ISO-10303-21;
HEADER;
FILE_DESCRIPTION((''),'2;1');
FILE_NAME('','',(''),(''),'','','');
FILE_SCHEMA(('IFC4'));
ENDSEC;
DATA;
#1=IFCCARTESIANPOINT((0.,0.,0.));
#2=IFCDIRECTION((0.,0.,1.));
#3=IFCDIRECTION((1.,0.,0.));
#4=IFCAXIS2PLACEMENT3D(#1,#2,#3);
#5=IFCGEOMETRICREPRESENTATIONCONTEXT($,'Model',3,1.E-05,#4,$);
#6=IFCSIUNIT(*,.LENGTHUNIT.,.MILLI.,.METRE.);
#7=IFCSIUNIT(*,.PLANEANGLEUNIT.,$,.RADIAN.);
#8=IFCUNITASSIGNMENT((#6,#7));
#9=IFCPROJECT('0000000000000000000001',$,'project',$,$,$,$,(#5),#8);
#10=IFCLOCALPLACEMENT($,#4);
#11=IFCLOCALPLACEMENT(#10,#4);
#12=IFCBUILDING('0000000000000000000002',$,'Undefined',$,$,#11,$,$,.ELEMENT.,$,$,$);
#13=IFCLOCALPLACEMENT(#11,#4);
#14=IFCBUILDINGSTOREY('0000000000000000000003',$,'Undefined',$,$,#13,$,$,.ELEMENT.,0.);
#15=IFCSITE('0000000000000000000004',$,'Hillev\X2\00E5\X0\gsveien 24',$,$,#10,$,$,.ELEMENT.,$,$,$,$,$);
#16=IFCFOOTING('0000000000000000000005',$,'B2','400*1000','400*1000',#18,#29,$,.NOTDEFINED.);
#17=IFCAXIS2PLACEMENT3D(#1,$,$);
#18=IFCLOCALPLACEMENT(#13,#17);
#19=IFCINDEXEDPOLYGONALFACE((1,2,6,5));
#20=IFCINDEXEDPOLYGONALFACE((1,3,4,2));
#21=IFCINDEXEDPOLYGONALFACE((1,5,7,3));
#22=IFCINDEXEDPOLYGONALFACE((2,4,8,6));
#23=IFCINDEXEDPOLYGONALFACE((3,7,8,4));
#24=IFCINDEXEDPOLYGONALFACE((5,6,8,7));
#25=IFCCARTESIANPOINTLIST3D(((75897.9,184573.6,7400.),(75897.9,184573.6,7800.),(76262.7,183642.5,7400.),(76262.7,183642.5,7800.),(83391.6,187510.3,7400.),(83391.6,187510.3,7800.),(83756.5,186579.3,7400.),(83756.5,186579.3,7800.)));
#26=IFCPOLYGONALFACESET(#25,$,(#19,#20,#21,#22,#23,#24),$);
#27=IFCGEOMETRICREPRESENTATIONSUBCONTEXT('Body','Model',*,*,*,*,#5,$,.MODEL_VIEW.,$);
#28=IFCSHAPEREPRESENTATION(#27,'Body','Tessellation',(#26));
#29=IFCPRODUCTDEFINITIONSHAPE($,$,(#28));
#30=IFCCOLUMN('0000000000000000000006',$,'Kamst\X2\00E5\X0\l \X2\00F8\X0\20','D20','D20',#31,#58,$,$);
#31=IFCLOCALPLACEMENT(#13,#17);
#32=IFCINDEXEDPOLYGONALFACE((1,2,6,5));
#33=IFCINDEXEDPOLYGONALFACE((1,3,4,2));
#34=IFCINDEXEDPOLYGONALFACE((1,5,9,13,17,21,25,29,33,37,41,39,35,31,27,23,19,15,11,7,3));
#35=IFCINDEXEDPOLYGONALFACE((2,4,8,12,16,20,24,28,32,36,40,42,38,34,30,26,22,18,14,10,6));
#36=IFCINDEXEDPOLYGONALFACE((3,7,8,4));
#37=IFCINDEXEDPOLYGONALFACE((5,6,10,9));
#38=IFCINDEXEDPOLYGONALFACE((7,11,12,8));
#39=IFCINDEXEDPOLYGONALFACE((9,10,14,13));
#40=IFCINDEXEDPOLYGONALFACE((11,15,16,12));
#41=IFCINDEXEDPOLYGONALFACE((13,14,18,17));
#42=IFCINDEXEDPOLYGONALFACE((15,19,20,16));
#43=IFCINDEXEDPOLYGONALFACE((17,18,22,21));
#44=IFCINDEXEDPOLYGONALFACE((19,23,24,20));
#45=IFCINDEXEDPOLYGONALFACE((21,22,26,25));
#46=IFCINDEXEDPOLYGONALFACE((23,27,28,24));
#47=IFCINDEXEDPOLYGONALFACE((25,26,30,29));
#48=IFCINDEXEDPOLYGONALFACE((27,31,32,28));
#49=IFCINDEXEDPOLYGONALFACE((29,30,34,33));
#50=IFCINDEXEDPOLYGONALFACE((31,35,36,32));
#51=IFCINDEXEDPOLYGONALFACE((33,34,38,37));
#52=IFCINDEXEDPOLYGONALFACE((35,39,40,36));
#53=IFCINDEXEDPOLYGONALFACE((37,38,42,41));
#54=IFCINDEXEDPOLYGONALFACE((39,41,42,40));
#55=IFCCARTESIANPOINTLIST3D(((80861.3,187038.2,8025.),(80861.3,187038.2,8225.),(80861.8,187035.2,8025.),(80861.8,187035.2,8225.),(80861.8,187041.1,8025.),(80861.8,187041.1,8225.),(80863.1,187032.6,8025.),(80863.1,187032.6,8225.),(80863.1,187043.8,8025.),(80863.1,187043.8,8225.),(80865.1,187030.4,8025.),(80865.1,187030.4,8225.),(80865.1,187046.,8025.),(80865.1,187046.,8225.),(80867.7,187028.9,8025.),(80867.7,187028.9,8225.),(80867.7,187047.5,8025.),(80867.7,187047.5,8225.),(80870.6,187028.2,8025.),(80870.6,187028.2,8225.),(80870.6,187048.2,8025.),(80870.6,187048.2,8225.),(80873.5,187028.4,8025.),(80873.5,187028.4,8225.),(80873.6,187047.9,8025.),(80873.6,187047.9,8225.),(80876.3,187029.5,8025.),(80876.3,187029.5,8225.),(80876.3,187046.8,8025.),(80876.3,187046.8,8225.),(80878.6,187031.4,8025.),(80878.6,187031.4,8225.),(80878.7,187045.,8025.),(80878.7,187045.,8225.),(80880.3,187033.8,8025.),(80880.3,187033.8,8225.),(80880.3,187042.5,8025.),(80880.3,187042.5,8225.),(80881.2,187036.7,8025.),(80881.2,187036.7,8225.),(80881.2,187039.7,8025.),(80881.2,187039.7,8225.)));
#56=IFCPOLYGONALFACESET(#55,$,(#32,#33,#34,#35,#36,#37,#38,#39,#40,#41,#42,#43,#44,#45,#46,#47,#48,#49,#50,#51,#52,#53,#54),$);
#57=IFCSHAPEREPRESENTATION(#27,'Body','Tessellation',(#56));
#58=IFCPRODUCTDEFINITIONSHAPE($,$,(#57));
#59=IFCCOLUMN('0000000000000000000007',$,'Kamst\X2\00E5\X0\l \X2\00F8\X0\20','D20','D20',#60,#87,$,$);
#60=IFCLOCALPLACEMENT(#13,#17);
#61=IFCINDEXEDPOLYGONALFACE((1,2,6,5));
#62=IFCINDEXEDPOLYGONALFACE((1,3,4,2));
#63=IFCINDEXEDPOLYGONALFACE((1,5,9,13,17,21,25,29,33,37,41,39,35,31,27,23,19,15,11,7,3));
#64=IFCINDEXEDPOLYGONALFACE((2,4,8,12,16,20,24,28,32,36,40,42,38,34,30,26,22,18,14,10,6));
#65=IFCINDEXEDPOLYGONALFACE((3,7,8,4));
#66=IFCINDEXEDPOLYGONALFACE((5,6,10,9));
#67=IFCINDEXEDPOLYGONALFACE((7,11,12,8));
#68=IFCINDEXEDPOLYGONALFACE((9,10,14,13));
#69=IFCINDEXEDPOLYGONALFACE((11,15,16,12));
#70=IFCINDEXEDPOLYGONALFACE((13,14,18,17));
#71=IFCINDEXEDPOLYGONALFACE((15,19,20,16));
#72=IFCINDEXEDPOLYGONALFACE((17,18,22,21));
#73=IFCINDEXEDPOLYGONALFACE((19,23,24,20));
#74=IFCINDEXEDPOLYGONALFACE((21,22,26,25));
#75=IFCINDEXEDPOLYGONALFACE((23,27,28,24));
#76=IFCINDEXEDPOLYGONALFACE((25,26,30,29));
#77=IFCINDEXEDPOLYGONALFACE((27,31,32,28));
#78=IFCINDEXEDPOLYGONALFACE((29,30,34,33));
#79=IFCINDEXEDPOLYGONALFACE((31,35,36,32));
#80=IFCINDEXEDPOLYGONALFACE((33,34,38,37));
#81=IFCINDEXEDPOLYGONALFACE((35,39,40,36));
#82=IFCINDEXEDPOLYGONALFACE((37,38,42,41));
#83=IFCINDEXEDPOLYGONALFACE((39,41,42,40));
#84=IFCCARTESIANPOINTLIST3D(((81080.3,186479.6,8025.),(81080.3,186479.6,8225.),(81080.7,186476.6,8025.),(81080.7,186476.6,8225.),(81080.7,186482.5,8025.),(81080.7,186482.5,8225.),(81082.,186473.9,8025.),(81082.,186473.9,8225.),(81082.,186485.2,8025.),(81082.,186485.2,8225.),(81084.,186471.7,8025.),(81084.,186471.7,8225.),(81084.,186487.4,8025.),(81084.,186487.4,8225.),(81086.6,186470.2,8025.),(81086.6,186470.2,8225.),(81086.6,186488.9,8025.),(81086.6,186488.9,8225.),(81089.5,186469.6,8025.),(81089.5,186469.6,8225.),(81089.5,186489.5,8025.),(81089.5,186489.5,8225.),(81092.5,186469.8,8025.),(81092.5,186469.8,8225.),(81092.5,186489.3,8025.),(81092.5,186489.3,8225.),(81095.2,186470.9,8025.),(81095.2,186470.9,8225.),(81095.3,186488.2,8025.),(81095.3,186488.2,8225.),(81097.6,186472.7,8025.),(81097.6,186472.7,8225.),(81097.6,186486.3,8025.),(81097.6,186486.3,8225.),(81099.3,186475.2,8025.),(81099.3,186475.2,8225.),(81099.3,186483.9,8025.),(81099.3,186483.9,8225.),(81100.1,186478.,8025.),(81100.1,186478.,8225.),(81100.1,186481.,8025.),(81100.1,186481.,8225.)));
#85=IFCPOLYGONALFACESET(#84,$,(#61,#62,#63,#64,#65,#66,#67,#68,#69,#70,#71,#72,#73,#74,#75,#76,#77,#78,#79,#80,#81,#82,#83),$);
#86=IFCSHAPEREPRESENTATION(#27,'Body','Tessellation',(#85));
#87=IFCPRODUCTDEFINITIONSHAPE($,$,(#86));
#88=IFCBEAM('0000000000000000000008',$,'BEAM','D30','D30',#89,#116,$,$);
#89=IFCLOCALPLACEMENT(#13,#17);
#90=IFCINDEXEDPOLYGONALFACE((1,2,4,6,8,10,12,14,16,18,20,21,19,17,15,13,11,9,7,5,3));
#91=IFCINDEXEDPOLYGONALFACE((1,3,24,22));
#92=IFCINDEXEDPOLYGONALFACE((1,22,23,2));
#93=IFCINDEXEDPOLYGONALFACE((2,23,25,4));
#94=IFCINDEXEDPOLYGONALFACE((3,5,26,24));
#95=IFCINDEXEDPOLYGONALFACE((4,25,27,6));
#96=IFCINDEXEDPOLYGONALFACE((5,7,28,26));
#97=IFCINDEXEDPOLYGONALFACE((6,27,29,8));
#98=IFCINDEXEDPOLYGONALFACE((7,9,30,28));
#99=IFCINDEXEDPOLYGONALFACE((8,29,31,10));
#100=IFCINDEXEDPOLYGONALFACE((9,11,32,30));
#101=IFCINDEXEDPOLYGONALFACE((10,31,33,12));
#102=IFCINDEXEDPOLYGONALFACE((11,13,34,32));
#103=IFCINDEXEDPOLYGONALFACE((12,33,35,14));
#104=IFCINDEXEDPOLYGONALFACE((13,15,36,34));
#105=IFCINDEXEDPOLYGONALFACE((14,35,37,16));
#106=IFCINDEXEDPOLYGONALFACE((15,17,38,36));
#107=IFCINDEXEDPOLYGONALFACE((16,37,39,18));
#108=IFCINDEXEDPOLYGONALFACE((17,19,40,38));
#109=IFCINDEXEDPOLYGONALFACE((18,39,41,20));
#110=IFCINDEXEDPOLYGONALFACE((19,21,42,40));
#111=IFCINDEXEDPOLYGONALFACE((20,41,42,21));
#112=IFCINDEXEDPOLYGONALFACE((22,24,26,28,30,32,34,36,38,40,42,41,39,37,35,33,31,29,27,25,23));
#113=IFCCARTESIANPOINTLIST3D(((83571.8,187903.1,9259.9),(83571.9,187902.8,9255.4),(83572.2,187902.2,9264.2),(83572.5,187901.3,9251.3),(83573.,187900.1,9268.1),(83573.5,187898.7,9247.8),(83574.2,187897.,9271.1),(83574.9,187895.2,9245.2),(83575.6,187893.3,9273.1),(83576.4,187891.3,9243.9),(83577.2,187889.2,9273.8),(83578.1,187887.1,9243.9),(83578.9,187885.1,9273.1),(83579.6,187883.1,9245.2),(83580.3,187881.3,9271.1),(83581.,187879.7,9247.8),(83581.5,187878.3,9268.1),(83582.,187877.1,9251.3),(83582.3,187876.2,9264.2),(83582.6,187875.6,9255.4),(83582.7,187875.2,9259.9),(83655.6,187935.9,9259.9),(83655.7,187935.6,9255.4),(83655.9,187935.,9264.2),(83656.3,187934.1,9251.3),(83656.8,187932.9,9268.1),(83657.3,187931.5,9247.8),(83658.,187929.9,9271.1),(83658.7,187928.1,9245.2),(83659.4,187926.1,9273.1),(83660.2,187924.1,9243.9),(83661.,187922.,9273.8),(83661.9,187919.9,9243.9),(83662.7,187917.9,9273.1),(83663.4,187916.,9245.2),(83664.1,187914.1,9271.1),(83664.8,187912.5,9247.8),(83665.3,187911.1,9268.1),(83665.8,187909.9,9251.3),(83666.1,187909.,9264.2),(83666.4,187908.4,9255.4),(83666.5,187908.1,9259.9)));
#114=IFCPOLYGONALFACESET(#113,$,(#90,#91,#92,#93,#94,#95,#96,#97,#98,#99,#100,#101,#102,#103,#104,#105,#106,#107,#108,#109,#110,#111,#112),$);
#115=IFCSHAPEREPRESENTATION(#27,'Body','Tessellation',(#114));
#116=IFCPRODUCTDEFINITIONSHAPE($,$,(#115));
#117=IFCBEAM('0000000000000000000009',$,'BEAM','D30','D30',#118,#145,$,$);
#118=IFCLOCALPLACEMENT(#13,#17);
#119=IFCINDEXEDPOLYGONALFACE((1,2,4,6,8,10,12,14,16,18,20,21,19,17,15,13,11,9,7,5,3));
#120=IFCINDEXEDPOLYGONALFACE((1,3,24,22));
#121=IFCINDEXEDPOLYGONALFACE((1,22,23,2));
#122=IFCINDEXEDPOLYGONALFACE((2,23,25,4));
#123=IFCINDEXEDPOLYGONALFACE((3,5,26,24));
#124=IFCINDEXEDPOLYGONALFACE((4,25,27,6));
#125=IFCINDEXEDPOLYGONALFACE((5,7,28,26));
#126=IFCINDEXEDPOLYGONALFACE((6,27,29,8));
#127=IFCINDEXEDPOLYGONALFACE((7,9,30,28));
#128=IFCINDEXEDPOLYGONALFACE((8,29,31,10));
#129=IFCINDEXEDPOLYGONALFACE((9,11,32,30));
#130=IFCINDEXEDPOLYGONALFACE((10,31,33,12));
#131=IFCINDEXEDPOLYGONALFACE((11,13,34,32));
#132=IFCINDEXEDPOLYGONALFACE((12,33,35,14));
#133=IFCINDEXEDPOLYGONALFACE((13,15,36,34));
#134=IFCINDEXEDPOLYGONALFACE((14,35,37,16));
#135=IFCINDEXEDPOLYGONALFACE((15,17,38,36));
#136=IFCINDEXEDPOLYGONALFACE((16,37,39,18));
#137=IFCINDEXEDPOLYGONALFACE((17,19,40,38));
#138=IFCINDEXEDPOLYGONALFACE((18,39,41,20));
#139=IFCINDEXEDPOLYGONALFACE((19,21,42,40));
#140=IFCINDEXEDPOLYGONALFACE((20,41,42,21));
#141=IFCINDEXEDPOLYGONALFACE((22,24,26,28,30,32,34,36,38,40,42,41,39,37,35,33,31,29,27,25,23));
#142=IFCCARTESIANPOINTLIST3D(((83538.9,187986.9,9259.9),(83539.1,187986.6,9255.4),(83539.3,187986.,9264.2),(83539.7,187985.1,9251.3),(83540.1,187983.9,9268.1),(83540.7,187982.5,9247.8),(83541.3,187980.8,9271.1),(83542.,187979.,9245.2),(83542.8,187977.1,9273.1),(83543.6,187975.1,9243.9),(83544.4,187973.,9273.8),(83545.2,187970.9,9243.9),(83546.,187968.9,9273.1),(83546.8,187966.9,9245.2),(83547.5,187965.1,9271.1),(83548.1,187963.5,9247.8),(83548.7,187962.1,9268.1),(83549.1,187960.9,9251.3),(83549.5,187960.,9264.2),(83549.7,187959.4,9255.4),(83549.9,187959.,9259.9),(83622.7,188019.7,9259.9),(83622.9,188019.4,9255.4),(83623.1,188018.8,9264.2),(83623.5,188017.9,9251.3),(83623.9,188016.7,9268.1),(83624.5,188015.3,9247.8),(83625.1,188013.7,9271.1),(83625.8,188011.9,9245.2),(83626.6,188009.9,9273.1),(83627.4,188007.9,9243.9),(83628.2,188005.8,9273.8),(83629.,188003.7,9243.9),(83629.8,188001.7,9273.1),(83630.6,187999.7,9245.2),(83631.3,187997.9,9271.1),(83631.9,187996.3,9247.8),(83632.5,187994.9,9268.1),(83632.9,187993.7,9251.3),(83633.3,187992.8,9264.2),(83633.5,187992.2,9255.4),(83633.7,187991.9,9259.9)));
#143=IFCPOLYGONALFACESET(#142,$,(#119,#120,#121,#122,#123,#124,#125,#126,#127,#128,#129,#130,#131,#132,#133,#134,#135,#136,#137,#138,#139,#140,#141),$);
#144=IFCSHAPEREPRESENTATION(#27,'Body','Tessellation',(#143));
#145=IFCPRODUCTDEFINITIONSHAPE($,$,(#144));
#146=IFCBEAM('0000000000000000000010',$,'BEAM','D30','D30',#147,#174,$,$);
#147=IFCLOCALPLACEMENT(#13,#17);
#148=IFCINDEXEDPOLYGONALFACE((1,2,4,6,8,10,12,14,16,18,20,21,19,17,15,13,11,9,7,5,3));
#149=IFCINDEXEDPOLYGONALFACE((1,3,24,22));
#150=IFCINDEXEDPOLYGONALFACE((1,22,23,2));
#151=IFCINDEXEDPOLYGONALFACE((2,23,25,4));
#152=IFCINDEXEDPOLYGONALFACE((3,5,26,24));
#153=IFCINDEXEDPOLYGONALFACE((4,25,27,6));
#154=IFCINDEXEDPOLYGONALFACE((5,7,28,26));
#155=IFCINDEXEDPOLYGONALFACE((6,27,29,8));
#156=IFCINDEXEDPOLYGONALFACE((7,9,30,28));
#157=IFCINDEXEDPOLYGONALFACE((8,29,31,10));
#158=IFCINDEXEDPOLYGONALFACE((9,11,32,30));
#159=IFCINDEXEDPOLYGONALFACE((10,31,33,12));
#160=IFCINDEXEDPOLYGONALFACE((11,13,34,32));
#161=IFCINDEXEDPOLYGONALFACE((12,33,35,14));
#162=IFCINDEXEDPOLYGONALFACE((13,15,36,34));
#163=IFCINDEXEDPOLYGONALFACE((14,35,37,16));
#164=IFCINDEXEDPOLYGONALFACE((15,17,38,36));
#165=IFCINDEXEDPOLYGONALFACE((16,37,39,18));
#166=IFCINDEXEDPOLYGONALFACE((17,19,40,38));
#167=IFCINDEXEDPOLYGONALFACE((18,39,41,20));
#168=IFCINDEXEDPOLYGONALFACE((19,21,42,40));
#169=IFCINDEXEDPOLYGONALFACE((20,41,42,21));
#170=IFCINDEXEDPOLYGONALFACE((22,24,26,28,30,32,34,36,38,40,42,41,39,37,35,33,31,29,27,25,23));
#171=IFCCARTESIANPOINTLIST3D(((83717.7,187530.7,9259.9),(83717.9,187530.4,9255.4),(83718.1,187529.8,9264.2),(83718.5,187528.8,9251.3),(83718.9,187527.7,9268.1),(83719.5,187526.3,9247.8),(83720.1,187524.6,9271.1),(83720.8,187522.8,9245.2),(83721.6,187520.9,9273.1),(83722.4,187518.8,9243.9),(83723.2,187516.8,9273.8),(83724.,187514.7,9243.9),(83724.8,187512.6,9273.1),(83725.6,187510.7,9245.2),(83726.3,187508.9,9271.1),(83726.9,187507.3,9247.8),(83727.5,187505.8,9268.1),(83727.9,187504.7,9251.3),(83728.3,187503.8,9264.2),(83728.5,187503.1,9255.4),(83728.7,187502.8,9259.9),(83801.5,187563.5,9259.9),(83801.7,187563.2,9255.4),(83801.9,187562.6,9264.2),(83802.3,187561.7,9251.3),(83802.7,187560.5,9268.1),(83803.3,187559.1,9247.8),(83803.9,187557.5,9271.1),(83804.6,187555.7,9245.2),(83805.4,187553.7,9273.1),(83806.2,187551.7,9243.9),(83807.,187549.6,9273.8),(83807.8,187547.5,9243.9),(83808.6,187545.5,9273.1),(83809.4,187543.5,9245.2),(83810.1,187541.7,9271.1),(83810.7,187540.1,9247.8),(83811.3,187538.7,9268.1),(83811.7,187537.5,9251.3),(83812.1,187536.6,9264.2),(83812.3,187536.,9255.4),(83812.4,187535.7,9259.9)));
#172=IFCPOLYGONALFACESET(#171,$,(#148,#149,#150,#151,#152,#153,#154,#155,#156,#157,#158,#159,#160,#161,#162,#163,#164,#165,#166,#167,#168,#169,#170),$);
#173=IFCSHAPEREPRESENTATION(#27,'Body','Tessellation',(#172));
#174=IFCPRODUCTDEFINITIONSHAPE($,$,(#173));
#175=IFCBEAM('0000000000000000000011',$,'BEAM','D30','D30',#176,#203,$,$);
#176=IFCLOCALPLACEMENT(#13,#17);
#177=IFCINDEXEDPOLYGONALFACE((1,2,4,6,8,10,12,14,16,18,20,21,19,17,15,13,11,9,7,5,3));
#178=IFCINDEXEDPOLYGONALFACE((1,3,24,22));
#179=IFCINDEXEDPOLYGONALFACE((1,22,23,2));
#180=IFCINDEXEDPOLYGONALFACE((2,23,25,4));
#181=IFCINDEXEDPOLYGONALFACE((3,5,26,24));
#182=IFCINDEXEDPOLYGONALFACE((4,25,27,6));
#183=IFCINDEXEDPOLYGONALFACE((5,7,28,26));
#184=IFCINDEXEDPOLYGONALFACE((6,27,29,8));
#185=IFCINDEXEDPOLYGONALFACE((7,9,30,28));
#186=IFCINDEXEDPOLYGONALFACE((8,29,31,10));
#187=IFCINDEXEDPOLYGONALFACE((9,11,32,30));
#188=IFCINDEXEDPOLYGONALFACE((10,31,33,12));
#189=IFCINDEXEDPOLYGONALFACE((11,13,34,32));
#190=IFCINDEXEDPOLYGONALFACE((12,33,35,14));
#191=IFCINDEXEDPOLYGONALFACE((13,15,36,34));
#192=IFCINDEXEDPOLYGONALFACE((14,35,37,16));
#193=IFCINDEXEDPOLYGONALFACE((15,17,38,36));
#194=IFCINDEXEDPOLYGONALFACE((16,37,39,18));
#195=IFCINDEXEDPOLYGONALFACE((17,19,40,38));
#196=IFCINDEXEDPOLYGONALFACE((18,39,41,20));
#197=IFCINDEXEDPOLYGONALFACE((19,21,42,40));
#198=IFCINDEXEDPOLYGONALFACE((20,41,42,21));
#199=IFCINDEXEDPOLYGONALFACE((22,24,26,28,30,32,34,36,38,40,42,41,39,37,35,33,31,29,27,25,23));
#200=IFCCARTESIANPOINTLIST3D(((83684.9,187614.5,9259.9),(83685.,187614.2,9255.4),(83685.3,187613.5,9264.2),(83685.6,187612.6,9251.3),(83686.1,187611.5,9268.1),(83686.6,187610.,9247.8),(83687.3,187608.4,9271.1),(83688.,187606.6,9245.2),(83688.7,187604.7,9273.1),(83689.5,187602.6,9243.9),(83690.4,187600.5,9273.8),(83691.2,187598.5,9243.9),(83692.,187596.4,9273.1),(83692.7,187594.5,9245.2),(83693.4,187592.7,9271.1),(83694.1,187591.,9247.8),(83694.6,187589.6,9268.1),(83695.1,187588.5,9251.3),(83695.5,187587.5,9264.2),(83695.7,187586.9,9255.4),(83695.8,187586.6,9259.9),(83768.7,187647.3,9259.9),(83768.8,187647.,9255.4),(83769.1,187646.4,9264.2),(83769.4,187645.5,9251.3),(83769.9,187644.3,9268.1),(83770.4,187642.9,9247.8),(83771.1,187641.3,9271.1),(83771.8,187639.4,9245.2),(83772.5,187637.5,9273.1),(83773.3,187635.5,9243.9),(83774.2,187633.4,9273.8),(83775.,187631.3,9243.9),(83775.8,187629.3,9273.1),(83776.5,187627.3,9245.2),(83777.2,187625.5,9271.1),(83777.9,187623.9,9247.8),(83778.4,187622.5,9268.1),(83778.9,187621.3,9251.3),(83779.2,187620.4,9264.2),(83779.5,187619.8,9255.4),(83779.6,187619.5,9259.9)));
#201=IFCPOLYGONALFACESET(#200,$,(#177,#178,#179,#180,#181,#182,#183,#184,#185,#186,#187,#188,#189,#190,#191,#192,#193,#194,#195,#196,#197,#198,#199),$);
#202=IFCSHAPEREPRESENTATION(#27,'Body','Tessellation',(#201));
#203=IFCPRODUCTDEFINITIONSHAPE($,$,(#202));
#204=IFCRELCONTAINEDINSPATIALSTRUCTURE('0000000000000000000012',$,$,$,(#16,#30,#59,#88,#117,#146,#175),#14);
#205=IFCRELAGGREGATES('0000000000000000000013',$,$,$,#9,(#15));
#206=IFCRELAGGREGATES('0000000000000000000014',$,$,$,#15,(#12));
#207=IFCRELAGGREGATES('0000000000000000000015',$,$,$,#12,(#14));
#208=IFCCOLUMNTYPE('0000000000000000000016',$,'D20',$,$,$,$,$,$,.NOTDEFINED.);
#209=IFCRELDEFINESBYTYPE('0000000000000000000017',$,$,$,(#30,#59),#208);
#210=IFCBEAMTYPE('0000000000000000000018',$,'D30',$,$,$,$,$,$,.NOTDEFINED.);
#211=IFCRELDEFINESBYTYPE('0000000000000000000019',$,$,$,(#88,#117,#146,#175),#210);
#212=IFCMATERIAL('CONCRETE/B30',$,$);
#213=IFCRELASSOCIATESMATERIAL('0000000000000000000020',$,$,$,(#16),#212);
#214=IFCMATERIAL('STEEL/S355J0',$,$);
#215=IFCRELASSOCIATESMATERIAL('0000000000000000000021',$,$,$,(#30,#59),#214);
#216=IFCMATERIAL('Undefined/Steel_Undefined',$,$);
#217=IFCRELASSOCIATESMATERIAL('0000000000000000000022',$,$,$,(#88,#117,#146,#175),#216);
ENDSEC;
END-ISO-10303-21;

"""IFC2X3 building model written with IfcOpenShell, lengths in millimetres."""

from ifc_helpers import new_model, si_unit, frame, frame_2d, origin_with_axes, place, context, subcontext, project, spatial, rectangle, circle, extrude, material, type_object, element, save


model = new_model("IFC2X3")

# Units and contexts
model_context = context("Model", 3, precision=1e-05, world=origin_with_axes())
body_context = subcontext(model_context, "Body", "Model", "MODEL_VIEW")
ifc_project = project(units=[si_unit("LENGTHUNIT", "METRE", prefix="MILLI"), si_unit("PLANEANGLEUNIT", "RADIAN")], contexts=[model_context])

# Site, building, storey
site_placement = place(None, origin_with_axes())
site = spatial("IfcSite", under=ifc_project, at=site_placement, Name="Hillevågsveien 24", CompositionType="ELEMENT")
building_placement = place(site_placement, origin_with_axes())
building = spatial("IfcBuilding", under=site, at=building_placement, Name="Undefined", CompositionType="ELEMENT")
storey_placement = place(building_placement, origin_with_axes())
storey = spatial("IfcBuildingStorey", under=building, at=storey_placement, Name="Undefined", CompositionType="ELEMENT", Elevation=0.0)

# Footing
ifc_material_1 = material(Name="CONCRETE/B30")
footing_placement = place(storey_placement, frame((83574.0, 187044.8, 7600.0), z_axis=(0.0, 0.0, 1.0), x_axis=(-0.931056, -0.364877, 0.0)))
element("IfcFooting", 1, at=footing_placement, inside=storey, material=ifc_material_1, Name="B2", Description="400*1000", ObjectType="400*1000", PredefinedType="NOTDEFINED", context=body_context, shape_type="SweptSolid", body=[
    extrude(rectangle(XDim=1000.0, YDim=400.0, at=frame_2d((0.0, 0.0), x_axis=(1.0, 0.0))), frame((8048.6, 0.0, 0.0), z_axis=(-1.0, 0.0, 0.0), x_axis=(0.0, -1.0, 0.0)), (0.0, 0.0, 1.0), 8048.6),
])

# Columns
ifc_material_2 = material(Name="STEEL/S355J0")
column_type = type_object("IfcColumnType", Name="D20", PredefinedType="NOTDEFINED")
for number, where, z_axis, x_axis, name in (
    (2, (80871.3, 187038.2, 8025.0), (0.0, 0.0, 1.0), (0.679441, -0.73373, 0.0), "Kamstål ø20"),
    (3, (81090.3, 186479.5, 8025.0), (0.0, 0.0, 1.0), (0.679441, -0.73373, 0.0), "Kamstål ø20"),
):
    element("IfcColumn", number, at=place(storey_placement, frame(where, z_axis=z_axis, x_axis=x_axis)), inside=storey, type_object=column_type, material=ifc_material_2, Name=name, Description="D20", ObjectType="D20", context=body_context, shape_type="SweptSolid", body=[
        extrude(circle(Radius=10.0, at=frame_2d((0.0, 0.0), x_axis=(1.0, 0.0))), frame((0.0, 0.0, 200.0), z_axis=(0.0, 0.0, -1.0), x_axis=(0.0, 1.0, 0.0)), (0.0, 0.0, 1.0), 200.0),
    ])

# Beams
ifc_material_3 = material(Name="Undefined/Steel_Undefined")
beam_type_1 = type_object("IfcBeamType", Name="D30", PredefinedType="NOTDEFINED")
for number, where, z_axis, x_axis, name in (
    (4, (83661.0, 187922.0, 9258.8), (0.364877, -0.931056, 0.0), (-0.931056, -0.364877, 0.0), "BEAM"),
    (5, (83628.2, 188005.8, 9258.8), (0.364877, -0.931056, 0.0), (-0.931056, -0.364877, 0.0), "BEAM"),
    (6, (83807.0, 187549.6, 9258.8), (0.364877, -0.931056, 0.0), (-0.931056, -0.364877, 0.0), "BEAM"),
    (7, (83774.2, 187633.4, 9258.8), (0.364877, -0.931056, 0.0), (-0.931056, -0.364877, 0.0), "BEAM"),
):
    element("IfcBeam", number, at=place(storey_placement, frame(where, z_axis=z_axis, x_axis=x_axis)), inside=storey, type_object=beam_type_1, material=ifc_material_3, Name=name, Description="D30", ObjectType="D30", context=body_context, shape_type="SweptSolid", body=[
        extrude(circle(Radius=15.0, at=frame_2d((0.0, 0.0), x_axis=(1.0, 0.0))), frame((90.0, 0.0, 0.0), z_axis=(-1.0, 0.0, 0.0), x_axis=(0.0, -1.0, 0.0)), (0.0, 0.0, 1.0), 90.0),
    ])

save(model, "model.ifc")
